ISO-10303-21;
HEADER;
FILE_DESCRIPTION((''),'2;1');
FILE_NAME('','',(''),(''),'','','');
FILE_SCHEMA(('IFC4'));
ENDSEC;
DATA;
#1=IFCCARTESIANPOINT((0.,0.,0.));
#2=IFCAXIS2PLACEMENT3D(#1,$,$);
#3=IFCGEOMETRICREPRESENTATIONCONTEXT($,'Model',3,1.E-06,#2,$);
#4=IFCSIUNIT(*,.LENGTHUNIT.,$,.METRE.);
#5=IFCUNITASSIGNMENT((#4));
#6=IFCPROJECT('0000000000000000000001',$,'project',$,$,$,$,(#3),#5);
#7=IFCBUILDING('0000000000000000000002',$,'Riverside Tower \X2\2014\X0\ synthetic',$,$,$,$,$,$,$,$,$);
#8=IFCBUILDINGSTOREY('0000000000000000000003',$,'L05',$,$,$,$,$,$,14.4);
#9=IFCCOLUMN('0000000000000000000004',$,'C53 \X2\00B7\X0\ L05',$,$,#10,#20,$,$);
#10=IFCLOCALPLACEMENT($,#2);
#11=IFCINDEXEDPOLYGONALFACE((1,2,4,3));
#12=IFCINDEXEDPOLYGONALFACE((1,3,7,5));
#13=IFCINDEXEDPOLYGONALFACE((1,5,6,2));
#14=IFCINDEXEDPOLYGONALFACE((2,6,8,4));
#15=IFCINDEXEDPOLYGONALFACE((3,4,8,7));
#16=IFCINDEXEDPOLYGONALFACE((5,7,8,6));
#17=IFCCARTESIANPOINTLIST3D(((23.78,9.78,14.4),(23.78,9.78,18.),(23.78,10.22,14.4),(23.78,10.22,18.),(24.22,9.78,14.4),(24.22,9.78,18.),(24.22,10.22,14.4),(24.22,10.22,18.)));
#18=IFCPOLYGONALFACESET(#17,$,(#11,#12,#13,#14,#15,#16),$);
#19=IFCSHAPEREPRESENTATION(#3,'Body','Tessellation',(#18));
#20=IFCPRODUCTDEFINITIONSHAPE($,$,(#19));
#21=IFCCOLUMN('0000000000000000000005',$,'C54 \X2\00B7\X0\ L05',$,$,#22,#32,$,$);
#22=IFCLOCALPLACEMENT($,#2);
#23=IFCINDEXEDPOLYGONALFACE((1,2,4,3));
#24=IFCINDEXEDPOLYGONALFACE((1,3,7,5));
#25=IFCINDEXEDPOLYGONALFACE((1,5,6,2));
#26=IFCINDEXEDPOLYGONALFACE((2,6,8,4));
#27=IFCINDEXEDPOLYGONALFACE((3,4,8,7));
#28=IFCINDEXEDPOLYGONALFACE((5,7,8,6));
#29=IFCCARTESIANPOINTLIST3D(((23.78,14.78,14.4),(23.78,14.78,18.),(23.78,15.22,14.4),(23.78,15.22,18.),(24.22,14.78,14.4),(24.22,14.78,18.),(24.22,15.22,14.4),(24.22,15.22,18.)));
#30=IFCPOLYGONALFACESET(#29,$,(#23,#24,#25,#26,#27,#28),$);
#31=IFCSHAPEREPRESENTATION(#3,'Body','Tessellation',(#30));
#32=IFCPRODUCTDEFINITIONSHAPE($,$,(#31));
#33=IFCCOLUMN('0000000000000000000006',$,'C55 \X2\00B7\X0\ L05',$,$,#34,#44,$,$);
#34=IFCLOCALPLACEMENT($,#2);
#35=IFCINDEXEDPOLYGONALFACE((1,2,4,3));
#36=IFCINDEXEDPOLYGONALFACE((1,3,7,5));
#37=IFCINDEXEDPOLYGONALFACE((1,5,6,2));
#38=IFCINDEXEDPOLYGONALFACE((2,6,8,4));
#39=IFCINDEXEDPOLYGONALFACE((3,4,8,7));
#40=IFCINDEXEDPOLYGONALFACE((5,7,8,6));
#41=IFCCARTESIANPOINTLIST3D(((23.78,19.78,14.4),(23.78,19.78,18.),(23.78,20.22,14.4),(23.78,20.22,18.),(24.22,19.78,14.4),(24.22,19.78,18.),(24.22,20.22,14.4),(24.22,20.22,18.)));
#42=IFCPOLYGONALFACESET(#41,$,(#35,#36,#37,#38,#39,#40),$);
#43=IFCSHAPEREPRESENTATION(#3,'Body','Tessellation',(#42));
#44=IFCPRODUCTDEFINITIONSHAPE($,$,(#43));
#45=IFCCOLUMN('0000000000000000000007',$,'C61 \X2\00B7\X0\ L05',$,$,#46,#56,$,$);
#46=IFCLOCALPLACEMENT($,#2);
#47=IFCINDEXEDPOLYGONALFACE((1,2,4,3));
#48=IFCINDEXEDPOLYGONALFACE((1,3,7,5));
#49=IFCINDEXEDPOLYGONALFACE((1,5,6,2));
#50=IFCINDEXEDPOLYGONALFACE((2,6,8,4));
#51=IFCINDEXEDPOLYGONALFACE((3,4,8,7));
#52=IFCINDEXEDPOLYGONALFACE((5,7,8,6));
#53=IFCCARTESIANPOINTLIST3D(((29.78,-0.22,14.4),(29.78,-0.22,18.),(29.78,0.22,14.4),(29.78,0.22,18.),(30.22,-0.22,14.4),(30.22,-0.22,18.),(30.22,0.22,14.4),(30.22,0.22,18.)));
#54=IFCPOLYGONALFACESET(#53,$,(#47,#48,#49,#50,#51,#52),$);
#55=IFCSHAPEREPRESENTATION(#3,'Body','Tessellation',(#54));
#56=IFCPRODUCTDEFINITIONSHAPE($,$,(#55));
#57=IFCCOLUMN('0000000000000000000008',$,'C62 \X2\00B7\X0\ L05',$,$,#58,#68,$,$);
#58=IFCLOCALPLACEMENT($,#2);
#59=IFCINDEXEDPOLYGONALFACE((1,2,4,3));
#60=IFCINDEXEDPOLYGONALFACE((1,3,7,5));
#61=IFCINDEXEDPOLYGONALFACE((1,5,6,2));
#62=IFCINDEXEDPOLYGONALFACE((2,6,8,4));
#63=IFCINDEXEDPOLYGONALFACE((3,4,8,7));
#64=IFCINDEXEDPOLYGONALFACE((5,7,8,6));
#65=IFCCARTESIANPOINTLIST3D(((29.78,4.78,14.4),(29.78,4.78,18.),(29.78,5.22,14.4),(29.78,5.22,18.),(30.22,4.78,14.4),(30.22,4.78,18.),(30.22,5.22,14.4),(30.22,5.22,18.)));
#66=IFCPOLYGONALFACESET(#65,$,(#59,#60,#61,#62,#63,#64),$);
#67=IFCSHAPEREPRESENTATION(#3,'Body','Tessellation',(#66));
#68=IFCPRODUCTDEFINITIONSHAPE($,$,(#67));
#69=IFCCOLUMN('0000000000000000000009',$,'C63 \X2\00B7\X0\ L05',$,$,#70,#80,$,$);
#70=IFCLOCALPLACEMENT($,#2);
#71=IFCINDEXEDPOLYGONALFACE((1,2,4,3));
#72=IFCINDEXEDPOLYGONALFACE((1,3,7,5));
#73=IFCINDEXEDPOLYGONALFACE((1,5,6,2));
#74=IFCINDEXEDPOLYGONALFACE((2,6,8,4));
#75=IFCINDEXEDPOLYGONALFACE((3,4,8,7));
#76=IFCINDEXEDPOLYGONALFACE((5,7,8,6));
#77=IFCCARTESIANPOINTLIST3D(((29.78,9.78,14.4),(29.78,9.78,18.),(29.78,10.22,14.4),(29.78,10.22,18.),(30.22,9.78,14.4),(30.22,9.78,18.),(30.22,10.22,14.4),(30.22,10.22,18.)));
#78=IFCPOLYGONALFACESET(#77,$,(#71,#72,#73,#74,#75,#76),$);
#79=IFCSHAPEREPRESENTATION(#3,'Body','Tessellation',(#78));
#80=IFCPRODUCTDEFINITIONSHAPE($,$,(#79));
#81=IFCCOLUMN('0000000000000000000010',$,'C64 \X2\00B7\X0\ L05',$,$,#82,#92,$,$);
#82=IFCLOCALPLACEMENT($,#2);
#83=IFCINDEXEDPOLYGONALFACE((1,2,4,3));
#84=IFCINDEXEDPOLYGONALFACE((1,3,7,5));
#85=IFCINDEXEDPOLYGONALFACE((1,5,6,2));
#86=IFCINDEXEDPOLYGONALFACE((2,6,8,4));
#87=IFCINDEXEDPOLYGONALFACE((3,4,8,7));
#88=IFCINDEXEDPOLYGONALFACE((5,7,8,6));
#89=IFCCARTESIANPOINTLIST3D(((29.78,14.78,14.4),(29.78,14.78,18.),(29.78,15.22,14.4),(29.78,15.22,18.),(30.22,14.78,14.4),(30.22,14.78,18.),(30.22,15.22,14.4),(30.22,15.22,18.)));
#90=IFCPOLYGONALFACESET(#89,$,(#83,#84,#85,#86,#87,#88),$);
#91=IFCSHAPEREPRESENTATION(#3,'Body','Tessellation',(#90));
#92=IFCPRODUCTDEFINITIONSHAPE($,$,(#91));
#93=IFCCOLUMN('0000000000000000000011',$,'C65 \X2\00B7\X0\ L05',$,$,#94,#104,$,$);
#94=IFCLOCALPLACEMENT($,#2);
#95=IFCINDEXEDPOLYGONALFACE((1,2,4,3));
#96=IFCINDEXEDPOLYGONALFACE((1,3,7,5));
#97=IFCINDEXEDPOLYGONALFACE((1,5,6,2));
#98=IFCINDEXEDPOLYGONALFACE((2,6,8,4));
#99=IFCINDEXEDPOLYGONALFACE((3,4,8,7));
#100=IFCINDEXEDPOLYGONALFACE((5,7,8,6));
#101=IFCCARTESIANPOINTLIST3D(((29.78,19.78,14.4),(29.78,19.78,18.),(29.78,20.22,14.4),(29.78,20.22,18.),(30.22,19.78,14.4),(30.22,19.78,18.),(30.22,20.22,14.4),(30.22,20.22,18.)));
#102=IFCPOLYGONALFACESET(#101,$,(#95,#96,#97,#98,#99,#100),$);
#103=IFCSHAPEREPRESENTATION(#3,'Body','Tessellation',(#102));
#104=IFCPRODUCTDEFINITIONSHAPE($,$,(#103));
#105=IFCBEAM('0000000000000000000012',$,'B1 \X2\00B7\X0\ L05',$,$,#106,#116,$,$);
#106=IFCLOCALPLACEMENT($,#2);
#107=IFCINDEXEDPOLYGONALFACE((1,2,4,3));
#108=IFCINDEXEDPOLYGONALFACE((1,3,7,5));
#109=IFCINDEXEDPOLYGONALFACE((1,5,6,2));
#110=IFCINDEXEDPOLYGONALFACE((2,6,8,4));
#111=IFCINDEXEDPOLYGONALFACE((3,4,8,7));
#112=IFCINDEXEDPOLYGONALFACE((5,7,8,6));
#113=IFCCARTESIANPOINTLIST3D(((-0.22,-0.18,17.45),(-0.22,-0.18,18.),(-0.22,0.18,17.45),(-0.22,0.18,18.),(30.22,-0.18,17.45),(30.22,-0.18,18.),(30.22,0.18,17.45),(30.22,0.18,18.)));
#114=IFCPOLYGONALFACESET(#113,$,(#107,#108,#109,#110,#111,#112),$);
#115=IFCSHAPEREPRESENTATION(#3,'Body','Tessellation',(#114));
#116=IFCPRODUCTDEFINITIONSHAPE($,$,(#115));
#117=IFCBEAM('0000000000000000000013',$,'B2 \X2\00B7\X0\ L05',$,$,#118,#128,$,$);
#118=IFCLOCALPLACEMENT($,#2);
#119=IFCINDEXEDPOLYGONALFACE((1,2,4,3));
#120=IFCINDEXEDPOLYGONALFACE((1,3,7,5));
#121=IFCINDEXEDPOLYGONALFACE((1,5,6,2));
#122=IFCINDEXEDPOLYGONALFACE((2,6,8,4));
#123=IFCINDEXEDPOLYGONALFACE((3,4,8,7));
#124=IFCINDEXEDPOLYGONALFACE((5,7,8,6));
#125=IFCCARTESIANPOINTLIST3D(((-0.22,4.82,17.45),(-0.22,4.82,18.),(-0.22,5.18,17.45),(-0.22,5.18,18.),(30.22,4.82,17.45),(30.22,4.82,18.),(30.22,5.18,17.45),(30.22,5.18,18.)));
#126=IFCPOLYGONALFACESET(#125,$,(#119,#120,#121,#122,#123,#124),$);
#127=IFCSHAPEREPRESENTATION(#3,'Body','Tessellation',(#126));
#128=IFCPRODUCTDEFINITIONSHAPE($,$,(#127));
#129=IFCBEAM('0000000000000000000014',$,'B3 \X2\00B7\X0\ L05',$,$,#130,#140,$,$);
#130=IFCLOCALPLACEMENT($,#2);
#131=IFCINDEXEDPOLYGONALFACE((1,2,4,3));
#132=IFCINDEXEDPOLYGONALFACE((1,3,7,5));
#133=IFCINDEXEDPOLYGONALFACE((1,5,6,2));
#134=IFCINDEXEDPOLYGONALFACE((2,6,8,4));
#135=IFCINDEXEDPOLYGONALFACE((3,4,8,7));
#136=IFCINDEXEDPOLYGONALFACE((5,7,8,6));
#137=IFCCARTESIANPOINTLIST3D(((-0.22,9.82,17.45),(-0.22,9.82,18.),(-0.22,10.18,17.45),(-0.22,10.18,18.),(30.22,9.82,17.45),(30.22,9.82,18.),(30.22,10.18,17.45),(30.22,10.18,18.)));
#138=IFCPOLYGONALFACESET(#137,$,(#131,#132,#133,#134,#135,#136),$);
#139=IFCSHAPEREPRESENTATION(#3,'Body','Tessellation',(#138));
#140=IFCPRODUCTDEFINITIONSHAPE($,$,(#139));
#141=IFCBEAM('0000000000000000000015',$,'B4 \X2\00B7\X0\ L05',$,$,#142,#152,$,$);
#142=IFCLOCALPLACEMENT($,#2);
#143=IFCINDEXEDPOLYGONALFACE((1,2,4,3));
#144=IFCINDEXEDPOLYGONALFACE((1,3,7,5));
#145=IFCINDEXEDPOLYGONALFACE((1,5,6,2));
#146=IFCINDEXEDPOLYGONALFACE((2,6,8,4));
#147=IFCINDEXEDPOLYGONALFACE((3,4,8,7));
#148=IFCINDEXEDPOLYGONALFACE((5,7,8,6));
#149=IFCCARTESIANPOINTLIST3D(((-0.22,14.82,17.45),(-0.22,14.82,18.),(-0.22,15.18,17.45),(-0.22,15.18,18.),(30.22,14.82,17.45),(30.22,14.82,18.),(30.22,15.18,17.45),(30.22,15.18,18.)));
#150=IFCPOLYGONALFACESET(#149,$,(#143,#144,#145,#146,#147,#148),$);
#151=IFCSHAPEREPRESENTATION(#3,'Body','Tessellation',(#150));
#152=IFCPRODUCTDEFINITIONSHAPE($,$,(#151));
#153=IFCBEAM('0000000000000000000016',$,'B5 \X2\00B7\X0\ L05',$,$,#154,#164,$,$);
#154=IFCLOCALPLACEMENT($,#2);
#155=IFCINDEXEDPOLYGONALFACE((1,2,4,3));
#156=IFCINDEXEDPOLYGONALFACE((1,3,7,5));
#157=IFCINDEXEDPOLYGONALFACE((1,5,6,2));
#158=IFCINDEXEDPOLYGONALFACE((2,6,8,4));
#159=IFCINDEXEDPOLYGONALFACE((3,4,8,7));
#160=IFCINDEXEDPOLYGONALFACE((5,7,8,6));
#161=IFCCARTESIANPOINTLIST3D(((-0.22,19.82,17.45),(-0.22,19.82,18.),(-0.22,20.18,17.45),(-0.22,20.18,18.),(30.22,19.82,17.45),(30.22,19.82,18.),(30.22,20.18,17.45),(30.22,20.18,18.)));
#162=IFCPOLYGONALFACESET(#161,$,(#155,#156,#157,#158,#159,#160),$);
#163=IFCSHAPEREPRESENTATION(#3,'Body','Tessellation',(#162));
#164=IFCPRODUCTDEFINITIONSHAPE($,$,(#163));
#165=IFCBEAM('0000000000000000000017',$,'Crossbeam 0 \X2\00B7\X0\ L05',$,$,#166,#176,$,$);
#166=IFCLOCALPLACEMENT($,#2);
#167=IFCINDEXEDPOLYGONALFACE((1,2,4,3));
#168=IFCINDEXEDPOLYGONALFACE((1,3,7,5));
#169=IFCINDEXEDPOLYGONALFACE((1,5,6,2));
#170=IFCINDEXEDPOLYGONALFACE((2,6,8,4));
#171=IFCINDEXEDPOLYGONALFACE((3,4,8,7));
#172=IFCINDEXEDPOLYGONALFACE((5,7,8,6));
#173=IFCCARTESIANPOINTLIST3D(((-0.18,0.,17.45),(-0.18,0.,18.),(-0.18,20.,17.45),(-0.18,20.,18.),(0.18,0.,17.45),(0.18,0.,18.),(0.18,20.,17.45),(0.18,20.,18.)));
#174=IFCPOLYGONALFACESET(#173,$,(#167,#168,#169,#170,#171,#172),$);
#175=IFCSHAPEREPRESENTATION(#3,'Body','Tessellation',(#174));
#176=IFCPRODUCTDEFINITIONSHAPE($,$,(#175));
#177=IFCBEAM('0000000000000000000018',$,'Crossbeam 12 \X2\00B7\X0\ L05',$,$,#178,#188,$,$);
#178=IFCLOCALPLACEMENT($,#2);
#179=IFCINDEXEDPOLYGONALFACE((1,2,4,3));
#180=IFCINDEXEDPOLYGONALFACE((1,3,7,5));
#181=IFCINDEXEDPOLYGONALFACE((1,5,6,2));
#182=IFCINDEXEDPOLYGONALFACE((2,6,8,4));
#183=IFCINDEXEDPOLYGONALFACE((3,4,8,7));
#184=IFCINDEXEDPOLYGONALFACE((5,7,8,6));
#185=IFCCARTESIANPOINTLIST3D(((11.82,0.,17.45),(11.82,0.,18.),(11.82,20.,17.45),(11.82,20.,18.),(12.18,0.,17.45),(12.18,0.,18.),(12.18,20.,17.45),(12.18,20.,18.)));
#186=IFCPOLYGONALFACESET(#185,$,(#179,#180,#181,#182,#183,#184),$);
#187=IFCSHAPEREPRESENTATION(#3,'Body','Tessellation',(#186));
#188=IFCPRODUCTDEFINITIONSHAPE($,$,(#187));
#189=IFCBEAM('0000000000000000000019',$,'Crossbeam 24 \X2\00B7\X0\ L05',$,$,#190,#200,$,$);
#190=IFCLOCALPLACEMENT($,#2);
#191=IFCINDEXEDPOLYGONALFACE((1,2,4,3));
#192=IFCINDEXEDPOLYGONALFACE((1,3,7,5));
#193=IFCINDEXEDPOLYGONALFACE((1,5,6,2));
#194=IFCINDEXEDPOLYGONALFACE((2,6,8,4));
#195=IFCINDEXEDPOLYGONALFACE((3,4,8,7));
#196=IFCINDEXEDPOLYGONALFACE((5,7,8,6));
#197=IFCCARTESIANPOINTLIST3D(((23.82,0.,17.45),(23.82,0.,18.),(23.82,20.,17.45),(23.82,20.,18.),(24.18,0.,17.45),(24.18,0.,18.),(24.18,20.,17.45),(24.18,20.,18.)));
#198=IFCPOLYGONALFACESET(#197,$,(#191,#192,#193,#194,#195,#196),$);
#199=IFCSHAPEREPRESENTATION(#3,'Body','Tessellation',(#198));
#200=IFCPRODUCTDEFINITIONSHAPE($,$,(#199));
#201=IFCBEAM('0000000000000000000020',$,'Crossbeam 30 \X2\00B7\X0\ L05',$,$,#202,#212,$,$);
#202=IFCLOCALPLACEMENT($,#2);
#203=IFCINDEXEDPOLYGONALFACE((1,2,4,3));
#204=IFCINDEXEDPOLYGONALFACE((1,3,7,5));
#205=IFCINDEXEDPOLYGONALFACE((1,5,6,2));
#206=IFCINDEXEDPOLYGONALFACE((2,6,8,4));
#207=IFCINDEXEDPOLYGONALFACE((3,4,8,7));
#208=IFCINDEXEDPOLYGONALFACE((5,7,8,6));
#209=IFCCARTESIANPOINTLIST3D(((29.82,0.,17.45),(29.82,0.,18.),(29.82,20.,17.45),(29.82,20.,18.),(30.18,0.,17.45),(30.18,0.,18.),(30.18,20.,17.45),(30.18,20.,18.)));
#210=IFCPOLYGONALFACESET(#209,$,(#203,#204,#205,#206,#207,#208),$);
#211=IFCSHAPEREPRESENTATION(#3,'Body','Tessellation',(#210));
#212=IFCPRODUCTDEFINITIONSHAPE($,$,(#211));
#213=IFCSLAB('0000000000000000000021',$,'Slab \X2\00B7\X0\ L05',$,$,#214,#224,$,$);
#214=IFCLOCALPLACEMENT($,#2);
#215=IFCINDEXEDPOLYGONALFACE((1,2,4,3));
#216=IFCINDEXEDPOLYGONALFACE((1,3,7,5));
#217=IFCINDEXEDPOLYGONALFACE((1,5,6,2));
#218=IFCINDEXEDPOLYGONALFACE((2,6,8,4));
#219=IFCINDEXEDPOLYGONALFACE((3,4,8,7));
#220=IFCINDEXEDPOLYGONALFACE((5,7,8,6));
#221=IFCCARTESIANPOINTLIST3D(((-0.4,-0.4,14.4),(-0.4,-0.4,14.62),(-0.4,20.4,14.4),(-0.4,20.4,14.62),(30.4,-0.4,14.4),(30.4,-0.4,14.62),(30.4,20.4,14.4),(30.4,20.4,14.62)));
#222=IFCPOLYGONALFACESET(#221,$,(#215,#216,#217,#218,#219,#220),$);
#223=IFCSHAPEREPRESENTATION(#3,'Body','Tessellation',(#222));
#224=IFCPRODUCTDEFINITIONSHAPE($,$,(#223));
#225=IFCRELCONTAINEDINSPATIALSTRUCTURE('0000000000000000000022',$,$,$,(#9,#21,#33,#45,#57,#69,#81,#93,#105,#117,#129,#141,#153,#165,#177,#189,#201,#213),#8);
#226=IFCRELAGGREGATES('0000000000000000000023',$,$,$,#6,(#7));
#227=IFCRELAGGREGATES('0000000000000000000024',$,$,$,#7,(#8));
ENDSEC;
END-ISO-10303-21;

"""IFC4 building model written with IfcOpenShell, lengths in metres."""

from ifc_helpers import new_model, si_unit, frame, origin, place, context, project, spatial, rectangle, extrude, element, save


model = new_model("IFC4")

# Units and contexts
model_context = context("Model", 3, precision=1e-06, world=origin())
ifc_project = project(units=[si_unit("LENGTHUNIT", "METRE")], contexts=[model_context])

# Building, storey
building = spatial("IfcBuilding", under=ifc_project, Name="Riverside Tower — synthetic")
storey = spatial("IfcBuildingStorey", under=building, Name="L05", Elevation=14.4)

# Columns
for number, where, name in (
    (1, (24.0, 10.0, 14.4), "C53 · L05"),
    (2, (24.0, 15.0, 14.4), "C54 · L05"),
    (3, (24.0, 20.0, 14.4), "C55 · L05"),
    (4, (30.0, 0.0, 14.4), "C61 · L05"),
    (5, (30.0, 5.0, 14.4), "C62 · L05"),
    (6, (30.0, 10.0, 14.4), "C63 · L05"),
    (7, (30.0, 15.0, 14.4), "C64 · L05"),
    (8, (30.0, 20.0, 14.4), "C65 · L05"),
):
    element("IfcColumn", number, at=place(None, frame(where)), inside=storey, Name=name, context=model_context, shape_type="SweptSolid", body=[
        extrude(rectangle(XDim=0.44, YDim=0.44), origin(), (0.0, 0.0, 1.0), 3.6),
    ])

# Beams
for number, where, name in (
    (9, (15.0, 0.0, 17.45), "B1 · L05"),
    (10, (15.0, 5.0, 17.45), "B2 · L05"),
    (11, (15.0, 10.0, 17.45), "B3 · L05"),
    (12, (15.0, 15.0, 17.45), "B4 · L05"),
    (13, (15.0, 20.0, 17.45), "B5 · L05"),
):
    element("IfcBeam", number, at=place(None, frame(where)), inside=storey, Name=name, context=model_context, shape_type="SweptSolid", body=[
        extrude(rectangle(XDim=30.44, YDim=0.36), origin(), (0.0, 0.0, 1.0), 0.55),
    ])
for number, where, name in (
    (14, (0.0, 10.0, 17.45), "Crossbeam 0 · L05"),
    (15, (12.0, 10.0, 17.45), "Crossbeam 12 · L05"),
    (16, (24.0, 10.0, 17.45), "Crossbeam 24 · L05"),
    (17, (30.0, 10.0, 17.45), "Crossbeam 30 · L05"),
):
    element("IfcBeam", number, at=place(None, frame(where)), inside=storey, Name=name, context=model_context, shape_type="SweptSolid", body=[
        extrude(rectangle(XDim=0.36, YDim=20.0), origin(), (0.0, 0.0, 1.0), 0.55),
    ])

# Slab
slab_placement = place(None, frame((15.0, 10.0, 14.4)))
element("IfcSlab", 18, at=slab_placement, inside=storey, Name="Slab · L05", context=model_context, shape_type="SweptSolid", body=[
    extrude(rectangle(XDim=30.8, YDim=20.8), origin(), (0.0, 0.0, 1.0), 0.22),
])

save(model, "model.ifc")
